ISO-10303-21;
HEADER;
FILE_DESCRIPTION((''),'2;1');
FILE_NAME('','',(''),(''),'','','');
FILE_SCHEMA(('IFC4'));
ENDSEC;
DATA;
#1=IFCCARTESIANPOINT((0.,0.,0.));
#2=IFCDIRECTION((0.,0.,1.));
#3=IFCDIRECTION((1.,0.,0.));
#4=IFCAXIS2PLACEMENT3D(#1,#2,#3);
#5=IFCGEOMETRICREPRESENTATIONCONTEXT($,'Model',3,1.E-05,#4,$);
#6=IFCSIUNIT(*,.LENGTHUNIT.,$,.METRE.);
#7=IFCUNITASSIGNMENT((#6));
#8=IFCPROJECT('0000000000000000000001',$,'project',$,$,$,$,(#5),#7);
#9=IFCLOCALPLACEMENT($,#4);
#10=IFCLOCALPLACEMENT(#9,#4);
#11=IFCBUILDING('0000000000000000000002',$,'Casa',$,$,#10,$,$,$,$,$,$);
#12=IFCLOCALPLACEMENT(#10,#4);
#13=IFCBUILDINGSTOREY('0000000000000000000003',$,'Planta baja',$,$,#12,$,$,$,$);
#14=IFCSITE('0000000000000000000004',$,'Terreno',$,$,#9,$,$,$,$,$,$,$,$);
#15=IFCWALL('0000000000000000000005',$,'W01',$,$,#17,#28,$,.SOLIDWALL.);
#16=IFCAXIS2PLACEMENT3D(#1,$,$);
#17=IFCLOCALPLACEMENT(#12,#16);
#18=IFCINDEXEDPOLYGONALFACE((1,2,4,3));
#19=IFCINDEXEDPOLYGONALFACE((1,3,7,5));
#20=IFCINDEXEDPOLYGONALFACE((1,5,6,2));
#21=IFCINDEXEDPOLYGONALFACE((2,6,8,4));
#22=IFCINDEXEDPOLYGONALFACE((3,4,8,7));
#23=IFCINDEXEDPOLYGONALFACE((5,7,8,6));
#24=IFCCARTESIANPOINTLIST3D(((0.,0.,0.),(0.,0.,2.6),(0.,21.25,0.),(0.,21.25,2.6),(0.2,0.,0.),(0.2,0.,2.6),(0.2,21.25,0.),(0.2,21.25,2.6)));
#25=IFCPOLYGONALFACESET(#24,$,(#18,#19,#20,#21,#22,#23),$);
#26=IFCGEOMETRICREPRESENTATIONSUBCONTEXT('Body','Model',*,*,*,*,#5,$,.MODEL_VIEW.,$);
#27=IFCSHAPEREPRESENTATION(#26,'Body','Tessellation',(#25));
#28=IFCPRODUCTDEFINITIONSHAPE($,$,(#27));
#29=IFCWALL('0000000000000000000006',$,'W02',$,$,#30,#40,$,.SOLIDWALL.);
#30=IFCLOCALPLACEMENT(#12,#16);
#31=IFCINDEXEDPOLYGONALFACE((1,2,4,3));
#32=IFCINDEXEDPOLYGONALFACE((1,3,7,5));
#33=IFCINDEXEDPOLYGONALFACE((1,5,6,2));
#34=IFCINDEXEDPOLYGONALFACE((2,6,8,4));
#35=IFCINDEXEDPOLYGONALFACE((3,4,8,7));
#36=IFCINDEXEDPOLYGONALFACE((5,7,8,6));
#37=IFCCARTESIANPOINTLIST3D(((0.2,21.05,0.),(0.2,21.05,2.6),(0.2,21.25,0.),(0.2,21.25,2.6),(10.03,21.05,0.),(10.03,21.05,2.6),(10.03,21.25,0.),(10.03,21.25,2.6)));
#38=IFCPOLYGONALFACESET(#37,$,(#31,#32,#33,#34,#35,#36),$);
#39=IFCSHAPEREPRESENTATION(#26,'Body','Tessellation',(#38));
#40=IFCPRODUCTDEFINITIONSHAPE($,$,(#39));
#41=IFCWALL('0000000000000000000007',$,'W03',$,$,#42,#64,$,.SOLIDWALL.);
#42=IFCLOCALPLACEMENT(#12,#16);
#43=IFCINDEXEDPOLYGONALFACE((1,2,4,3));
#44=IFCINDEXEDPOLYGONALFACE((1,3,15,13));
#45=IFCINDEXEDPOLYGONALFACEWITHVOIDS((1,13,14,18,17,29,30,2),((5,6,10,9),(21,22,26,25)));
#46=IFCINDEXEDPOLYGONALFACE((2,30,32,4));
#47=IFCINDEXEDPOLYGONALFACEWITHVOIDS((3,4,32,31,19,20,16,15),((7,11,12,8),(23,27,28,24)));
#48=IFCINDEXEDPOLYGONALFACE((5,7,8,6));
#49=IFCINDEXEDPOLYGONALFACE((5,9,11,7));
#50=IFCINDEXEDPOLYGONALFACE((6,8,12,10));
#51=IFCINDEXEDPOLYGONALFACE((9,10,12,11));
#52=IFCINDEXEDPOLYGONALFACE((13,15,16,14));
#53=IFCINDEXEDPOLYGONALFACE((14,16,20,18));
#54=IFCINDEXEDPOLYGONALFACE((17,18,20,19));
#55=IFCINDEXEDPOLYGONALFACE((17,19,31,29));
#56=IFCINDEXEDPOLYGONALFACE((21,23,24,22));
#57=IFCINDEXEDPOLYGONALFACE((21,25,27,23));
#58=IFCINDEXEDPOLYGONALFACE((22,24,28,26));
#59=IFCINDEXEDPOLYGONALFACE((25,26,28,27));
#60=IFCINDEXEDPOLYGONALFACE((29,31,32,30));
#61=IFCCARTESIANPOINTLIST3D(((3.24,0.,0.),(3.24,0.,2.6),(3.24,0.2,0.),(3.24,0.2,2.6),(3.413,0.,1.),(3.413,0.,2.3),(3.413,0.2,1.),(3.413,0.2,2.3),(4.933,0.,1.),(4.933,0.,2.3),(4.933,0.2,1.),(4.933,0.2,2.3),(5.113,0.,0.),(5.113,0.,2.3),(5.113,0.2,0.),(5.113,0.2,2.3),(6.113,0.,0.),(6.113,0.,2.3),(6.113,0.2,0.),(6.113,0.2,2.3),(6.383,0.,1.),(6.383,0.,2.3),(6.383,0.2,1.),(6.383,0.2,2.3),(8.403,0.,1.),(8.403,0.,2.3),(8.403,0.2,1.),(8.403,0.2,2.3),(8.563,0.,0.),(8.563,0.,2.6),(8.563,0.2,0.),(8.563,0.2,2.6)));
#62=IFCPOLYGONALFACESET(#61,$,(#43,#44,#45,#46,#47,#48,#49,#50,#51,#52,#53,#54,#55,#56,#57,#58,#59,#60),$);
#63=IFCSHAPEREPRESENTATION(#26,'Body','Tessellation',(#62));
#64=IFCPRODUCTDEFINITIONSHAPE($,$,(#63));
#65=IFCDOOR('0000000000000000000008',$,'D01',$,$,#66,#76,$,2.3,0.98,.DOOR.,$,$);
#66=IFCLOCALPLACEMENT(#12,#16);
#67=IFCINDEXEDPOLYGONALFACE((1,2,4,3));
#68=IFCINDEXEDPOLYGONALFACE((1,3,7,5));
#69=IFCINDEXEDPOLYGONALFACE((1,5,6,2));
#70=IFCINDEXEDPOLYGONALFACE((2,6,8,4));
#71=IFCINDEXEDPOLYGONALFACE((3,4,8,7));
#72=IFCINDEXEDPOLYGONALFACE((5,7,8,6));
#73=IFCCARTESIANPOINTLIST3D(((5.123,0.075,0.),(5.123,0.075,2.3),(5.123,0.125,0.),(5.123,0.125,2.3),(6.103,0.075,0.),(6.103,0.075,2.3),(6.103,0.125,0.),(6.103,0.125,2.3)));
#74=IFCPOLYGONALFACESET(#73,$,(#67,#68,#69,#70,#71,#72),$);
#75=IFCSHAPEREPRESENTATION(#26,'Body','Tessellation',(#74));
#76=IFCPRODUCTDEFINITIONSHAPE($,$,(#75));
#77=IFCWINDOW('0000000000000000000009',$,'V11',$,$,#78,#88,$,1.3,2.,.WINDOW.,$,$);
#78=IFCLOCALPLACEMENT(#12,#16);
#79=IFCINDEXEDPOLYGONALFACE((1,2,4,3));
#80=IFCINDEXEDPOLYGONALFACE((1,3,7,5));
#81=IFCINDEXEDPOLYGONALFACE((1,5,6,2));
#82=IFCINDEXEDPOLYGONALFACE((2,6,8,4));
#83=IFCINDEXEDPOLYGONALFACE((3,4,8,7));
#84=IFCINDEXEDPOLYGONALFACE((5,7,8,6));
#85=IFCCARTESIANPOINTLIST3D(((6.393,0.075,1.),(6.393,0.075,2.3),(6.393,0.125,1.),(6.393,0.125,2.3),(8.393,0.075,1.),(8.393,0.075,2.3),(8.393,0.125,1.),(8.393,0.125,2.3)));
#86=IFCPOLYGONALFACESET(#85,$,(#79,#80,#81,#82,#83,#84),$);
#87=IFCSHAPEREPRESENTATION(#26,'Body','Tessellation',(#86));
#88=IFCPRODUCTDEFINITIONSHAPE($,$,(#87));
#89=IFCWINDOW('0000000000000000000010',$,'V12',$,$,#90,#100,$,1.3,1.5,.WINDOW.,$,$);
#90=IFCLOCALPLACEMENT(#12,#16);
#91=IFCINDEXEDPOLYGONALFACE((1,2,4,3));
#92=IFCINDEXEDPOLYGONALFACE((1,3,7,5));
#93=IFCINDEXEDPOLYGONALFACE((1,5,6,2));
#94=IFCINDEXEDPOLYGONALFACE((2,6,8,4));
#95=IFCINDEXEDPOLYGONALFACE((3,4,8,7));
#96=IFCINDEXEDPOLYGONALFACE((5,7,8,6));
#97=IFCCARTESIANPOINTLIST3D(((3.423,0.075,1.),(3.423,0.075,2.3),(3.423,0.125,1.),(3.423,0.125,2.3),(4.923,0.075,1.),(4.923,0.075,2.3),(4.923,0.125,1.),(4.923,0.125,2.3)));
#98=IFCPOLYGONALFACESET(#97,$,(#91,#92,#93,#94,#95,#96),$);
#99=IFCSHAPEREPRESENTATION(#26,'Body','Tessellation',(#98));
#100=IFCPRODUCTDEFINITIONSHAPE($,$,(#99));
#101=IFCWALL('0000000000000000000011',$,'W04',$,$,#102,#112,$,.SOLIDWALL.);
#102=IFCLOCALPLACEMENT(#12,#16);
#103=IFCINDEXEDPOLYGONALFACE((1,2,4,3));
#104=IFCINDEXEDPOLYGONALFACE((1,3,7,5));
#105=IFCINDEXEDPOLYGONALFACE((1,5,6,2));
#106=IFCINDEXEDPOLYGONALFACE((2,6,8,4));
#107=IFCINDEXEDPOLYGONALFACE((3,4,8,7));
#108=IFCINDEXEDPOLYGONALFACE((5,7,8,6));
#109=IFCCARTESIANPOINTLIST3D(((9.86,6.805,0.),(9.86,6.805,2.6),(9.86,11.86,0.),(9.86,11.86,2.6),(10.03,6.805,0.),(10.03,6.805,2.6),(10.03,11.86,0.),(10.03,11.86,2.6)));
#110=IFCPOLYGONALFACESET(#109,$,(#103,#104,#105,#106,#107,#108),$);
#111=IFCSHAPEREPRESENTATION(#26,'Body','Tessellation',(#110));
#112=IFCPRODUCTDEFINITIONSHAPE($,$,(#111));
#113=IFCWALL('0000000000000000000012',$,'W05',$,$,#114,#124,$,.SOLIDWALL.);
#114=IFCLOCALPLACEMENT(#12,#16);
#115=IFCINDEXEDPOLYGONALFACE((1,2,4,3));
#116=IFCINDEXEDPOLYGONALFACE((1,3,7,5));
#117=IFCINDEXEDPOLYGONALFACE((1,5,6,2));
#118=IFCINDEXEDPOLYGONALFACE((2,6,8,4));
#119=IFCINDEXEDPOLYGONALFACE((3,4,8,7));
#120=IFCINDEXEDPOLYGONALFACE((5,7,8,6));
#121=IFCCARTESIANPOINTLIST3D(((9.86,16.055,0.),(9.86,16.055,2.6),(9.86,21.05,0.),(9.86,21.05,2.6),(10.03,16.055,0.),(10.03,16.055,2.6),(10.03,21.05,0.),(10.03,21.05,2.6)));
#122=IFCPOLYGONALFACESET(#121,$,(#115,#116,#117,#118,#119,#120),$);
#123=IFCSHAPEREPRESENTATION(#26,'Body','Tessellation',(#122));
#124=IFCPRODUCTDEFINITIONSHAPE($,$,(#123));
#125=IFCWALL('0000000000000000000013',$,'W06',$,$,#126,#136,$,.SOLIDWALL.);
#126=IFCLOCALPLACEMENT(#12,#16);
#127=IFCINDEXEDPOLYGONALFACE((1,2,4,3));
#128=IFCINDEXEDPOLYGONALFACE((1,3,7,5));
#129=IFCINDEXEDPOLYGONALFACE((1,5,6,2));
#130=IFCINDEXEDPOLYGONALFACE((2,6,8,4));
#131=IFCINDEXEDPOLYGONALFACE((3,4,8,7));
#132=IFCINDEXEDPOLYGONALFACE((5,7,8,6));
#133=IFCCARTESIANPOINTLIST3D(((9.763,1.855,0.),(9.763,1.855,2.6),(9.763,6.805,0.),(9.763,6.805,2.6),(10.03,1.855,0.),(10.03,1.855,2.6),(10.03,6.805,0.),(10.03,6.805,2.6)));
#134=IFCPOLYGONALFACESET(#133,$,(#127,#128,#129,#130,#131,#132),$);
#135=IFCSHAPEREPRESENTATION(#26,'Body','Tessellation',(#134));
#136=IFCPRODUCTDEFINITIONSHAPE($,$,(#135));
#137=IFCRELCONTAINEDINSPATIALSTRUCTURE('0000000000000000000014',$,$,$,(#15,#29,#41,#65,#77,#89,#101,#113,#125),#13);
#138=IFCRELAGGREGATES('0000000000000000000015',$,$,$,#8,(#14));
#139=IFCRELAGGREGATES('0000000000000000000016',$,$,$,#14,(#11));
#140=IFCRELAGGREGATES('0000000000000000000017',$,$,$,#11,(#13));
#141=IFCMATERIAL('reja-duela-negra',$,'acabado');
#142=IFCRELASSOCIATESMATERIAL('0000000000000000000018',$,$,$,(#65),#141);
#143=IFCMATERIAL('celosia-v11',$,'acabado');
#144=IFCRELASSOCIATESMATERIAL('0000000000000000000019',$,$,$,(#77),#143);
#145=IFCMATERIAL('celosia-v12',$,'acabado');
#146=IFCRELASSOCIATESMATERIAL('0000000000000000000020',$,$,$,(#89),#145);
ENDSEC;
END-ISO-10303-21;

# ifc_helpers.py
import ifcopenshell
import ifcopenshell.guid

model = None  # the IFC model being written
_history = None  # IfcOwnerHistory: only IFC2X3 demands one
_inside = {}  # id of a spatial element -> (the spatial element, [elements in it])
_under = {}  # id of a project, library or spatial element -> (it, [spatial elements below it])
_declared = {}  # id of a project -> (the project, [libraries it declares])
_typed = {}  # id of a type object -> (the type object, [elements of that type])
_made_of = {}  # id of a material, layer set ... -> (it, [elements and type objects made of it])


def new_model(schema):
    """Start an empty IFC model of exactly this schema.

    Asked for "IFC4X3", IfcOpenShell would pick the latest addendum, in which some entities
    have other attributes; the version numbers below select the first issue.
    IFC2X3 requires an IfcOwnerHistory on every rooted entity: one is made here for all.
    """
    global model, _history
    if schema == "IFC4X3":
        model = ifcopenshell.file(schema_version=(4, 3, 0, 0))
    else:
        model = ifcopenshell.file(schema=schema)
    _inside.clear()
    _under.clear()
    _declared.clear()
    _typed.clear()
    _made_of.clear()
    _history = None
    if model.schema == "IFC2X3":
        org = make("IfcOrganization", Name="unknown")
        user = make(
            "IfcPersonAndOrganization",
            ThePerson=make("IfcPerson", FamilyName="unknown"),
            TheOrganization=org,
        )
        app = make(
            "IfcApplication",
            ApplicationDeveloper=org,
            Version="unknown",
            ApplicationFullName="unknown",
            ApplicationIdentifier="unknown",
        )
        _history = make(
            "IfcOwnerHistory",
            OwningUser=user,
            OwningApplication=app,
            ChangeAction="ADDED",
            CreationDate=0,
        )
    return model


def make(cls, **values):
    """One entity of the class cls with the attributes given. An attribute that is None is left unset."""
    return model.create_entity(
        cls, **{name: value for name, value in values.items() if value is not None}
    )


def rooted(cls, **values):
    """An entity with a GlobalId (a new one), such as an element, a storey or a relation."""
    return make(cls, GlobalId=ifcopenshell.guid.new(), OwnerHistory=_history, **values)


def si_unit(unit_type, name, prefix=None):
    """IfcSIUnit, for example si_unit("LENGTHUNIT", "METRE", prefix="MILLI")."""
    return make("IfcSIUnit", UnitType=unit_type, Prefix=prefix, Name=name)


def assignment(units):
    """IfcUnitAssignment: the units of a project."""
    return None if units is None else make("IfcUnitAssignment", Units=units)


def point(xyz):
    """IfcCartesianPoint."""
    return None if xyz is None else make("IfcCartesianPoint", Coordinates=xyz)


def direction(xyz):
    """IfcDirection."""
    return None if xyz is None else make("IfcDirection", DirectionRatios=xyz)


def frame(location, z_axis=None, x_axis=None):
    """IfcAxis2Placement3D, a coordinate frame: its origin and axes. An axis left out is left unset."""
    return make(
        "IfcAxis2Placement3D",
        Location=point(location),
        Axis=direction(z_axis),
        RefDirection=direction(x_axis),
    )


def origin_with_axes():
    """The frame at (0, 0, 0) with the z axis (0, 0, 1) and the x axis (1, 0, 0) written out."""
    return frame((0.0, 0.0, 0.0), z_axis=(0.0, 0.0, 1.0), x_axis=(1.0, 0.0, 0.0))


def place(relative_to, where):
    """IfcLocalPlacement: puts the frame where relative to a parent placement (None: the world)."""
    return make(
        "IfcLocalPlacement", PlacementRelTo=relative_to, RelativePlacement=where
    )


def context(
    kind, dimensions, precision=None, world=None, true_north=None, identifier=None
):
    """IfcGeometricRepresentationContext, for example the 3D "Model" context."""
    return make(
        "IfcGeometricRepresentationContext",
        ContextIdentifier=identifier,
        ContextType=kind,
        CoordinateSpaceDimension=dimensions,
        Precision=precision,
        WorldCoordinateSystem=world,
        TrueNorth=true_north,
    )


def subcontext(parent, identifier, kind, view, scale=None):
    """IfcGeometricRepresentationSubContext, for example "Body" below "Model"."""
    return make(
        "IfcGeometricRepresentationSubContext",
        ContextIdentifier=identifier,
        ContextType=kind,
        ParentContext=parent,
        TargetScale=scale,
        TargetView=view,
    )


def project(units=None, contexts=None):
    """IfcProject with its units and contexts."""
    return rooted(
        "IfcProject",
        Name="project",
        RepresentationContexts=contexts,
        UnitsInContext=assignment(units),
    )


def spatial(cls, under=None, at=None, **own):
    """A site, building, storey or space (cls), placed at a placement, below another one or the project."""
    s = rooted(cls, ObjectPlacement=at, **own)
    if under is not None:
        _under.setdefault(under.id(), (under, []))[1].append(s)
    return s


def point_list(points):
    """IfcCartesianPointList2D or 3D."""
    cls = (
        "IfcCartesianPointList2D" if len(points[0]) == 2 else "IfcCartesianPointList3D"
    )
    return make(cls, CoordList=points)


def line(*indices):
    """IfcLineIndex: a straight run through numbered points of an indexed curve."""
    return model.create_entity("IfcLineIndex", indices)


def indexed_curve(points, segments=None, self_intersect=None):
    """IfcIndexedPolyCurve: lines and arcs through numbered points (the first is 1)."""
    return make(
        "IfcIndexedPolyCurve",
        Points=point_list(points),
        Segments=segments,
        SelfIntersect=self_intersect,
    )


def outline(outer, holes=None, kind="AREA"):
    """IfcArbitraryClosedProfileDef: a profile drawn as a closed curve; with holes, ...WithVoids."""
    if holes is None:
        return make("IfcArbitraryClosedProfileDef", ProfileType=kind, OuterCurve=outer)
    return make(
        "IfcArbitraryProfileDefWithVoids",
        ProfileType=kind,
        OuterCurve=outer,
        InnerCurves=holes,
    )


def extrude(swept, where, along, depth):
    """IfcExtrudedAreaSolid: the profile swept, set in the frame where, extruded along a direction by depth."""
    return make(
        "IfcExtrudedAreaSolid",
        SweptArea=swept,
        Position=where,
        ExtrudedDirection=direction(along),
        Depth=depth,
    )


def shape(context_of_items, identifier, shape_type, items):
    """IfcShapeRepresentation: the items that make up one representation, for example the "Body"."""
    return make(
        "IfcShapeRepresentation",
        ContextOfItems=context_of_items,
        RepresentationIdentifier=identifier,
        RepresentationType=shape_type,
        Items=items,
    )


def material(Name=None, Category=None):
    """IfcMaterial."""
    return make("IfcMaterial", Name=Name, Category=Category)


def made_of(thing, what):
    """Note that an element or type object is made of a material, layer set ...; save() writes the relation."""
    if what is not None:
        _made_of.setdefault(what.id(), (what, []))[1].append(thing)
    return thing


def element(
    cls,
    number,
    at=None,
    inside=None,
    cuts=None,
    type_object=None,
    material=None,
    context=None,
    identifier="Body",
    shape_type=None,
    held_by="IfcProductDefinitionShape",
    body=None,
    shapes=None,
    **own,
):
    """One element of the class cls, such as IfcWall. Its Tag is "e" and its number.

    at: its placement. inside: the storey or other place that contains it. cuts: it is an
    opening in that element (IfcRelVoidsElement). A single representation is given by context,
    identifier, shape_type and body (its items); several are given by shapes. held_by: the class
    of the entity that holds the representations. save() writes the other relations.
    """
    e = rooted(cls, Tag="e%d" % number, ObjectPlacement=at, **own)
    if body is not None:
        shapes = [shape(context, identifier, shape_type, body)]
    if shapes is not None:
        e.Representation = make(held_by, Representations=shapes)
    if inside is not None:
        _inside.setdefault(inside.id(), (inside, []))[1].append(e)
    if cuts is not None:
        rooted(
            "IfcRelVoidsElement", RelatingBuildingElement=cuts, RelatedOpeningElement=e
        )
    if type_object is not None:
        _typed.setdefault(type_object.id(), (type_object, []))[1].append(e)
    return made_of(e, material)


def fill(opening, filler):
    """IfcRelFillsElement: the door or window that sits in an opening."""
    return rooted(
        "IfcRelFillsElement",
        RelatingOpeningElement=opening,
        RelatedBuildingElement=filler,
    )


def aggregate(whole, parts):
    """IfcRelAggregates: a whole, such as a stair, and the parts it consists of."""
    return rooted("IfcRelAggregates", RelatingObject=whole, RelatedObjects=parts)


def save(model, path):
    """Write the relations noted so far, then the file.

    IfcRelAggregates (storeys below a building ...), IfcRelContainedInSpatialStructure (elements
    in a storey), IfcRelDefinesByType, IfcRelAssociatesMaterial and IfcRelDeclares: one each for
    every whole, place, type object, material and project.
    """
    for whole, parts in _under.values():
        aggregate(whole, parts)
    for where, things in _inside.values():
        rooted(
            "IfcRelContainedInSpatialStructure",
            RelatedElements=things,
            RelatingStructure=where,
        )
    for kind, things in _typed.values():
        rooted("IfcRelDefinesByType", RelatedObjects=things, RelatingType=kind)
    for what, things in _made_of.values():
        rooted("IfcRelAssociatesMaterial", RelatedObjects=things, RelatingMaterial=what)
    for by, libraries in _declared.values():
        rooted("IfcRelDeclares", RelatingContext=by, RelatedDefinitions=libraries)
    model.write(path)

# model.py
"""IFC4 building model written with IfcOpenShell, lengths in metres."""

from ifc_helpers import new_model, si_unit, frame, origin_with_axes, place, context, subcontext, project, spatial, line, indexed_curve, outline, extrude, material, element, fill, save


model = new_model("IFC4")

# Units and contexts
model_context = context("Model", 3, precision=1e-05, world=origin_with_axes())
body_context = subcontext(model_context, "Body", "Model", "MODEL_VIEW")
ifc_project = project(units=[si_unit("LENGTHUNIT", "METRE")], contexts=[model_context])

# Site, building, storey
site_placement = place(None, origin_with_axes())
site = spatial("IfcSite", under=ifc_project, at=site_placement, Name="Terreno")
building_placement = place(site_placement, origin_with_axes())
building = spatial("IfcBuilding", under=site, at=building_placement, Name="Casa")
storey_placement = place(building_placement, origin_with_axes())
storey = spatial("IfcBuildingStorey", under=building, at=storey_placement, Name="Planta baja")

# Walls
wall_1_placement = place(storey_placement, origin_with_axes())
element("IfcWall", 1, at=wall_1_placement, inside=storey, Name="W01", PredefinedType="SOLIDWALL", context=body_context, shape_type="SweptSolid", body=[
    extrude(outline(indexed_curve([(0.2, 0.0), (0.0, 0.0), (0.0, 21.25), (0.2, 21.25)], segments=[line(1, 2, 3, 4, 1)])), origin_with_axes(), (0.0, 0.0, 1.0), 2.6),
])
wall_2_placement = place(storey_placement, origin_with_axes())
element("IfcWall", 2, at=wall_2_placement, inside=storey, Name="W02", PredefinedType="SOLIDWALL", context=body_context, shape_type="SweptSolid", body=[
    extrude(outline(indexed_curve([(0.2, 21.05), (0.2, 21.25), (10.03, 21.25), (10.03, 21.05)], segments=[line(1, 2, 3, 4, 1)])), origin_with_axes(), (0.0, 0.0, 1.0), 2.6),
])

# Wall, openings, door, windows
wall_3_placement = place(storey_placement, origin_with_axes())
wall_3 = element("IfcWall", 3, at=wall_3_placement, inside=storey, Name="W03", PredefinedType="SOLIDWALL", context=body_context, shape_type="SweptSolid", body=[
    extrude(outline(indexed_curve([(3.24, 0.2), (8.563, 0.2), (8.563, 0.0), (3.24, 0.0)], segments=[line(1, 2, 3, 4, 1)])), origin_with_axes(), (0.0, 0.0, 1.0), 2.6),
])
opening_1_placement = place(wall_3_placement, origin_with_axes())
opening_1 = element("IfcOpeningElement", 4, at=opening_1_placement, cuts=wall_3, PredefinedType="OPENING", context=body_context, shape_type="SweptSolid", body=[
    extrude(outline(indexed_curve([(5.113, -0.01), (6.113, -0.01), (6.113, 0.21), (5.113, 0.21)], segments=[line(1, 2, 3, 4, 1)])), origin_with_axes(), (0.0, 0.0, 1.0), 2.3),
])
opening_2_placement = place(wall_3_placement, origin_with_axes())
opening_2 = element("IfcOpeningElement", 5, at=opening_2_placement, cuts=wall_3, PredefinedType="OPENING", context=body_context, shape_type="SweptSolid", body=[
    extrude(outline(indexed_curve([(6.383, -0.01), (8.403, -0.01), (8.403, 0.21), (6.383, 0.21)], segments=[line(1, 2, 3, 4, 1)])), frame((0.0, 0.0, 1.0), z_axis=(0.0, 0.0, 1.0), x_axis=(1.0, 0.0, 0.0)), (0.0, 0.0, 1.0), 1.3),
])
opening_3_placement = place(wall_3_placement, origin_with_axes())
opening_3 = element("IfcOpeningElement", 6, at=opening_3_placement, cuts=wall_3, PredefinedType="OPENING", context=body_context, shape_type="SweptSolid", body=[
    extrude(outline(indexed_curve([(3.413, -0.01), (4.933, -0.01), (4.933, 0.21), (3.413, 0.21)], segments=[line(1, 2, 3, 4, 1)])), frame((0.0, 0.0, 1.0), z_axis=(0.0, 0.0, 1.0), x_axis=(1.0, 0.0, 0.0)), (0.0, 0.0, 1.0), 1.3),
])
ifc_material_1 = material(Name="reja-duela-negra", Category="acabado")
door_1_placement = place(opening_1_placement, origin_with_axes())
door_1 = element("IfcDoor", 7, at=door_1_placement, inside=storey, material=ifc_material_1, Name="D01", OverallHeight=2.3, OverallWidth=0.98, PredefinedType="DOOR", context=body_context, shape_type="SweptSolid", body=[
    extrude(outline(indexed_curve([(5.123, 0.075), (6.103, 0.075), (6.103, 0.125), (5.123, 0.125)], segments=[line(1, 2, 3, 4, 1)])), origin_with_axes(), (0.0, 0.0, 1.0), 2.3),
])
fill(opening_1, door_1)
ifc_material_2 = material(Name="celosia-v11", Category="acabado")
window_1_placement = place(opening_2_placement, origin_with_axes())
window_1 = element("IfcWindow", 8, at=window_1_placement, inside=storey, material=ifc_material_2, Name="V11", OverallHeight=1.3, OverallWidth=2.0, PredefinedType="WINDOW", context=body_context, shape_type="SweptSolid", body=[
    extrude(outline(indexed_curve([(6.393, 0.075), (8.393, 0.075), (8.393, 0.125), (6.393, 0.125)], segments=[line(1, 2, 3, 4, 1)])), frame((0.0, 0.0, 1.0), z_axis=(0.0, 0.0, 1.0), x_axis=(1.0, 0.0, 0.0)), (0.0, 0.0, 1.0), 1.3),
])
fill(opening_2, window_1)
ifc_material_3 = material(Name="celosia-v12", Category="acabado")
window_2_placement = place(opening_3_placement, origin_with_axes())
window_2 = element("IfcWindow", 9, at=window_2_placement, inside=storey, material=ifc_material_3, Name="V12", OverallHeight=1.3, OverallWidth=1.5, PredefinedType="WINDOW", context=body_context, shape_type="SweptSolid", body=[
    extrude(outline(indexed_curve([(3.423, 0.075), (4.923, 0.075), (4.923, 0.125), (3.423, 0.125)], segments=[line(1, 2, 3, 4, 1)])), frame((0.0, 0.0, 1.0), z_axis=(0.0, 0.0, 1.0), x_axis=(1.0, 0.0, 0.0)), (0.0, 0.0, 1.0), 1.3),
])
fill(opening_3, window_2)

# Walls
wall_4_placement = place(storey_placement, origin_with_axes())
element("IfcWall", 10, at=wall_4_placement, inside=storey, Name="W04", PredefinedType="SOLIDWALL", context=body_context, shape_type="SweptSolid", body=[
    extrude(outline(indexed_curve([(9.86, 11.86), (10.03, 11.86), (10.03, 6.805), (9.86, 6.805)], segments=[line(1, 2, 3, 4, 1)])), origin_with_axes(), (0.0, 0.0, 1.0), 2.6),
])
wall_5_placement = place(storey_placement, origin_with_axes())
element("IfcWall", 11, at=wall_5_placement, inside=storey, Name="W05", PredefinedType="SOLIDWALL", context=body_context, shape_type="SweptSolid", body=[
    extrude(outline(indexed_curve([(9.86, 21.05), (10.03, 21.05), (10.03, 16.055), (9.86, 16.055)], segments=[line(1, 2, 3, 4, 1)])), origin_with_axes(), (0.0, 0.0, 1.0), 2.6),
])
wall_6_placement = place(storey_placement, origin_with_axes())
element("IfcWall", 12, at=wall_6_placement, inside=storey, Name="W06", PredefinedType="SOLIDWALL", context=body_context, shape_type="SweptSolid", body=[
    extrude(outline(indexed_curve([(9.763, 6.805), (10.03, 6.805), (10.03, 1.855), (9.763, 1.855)], segments=[line(1, 2, 3, 4, 1)])), origin_with_axes(), (0.0, 0.0, 1.0), 2.6),
])

save(model, "model.ifc")
